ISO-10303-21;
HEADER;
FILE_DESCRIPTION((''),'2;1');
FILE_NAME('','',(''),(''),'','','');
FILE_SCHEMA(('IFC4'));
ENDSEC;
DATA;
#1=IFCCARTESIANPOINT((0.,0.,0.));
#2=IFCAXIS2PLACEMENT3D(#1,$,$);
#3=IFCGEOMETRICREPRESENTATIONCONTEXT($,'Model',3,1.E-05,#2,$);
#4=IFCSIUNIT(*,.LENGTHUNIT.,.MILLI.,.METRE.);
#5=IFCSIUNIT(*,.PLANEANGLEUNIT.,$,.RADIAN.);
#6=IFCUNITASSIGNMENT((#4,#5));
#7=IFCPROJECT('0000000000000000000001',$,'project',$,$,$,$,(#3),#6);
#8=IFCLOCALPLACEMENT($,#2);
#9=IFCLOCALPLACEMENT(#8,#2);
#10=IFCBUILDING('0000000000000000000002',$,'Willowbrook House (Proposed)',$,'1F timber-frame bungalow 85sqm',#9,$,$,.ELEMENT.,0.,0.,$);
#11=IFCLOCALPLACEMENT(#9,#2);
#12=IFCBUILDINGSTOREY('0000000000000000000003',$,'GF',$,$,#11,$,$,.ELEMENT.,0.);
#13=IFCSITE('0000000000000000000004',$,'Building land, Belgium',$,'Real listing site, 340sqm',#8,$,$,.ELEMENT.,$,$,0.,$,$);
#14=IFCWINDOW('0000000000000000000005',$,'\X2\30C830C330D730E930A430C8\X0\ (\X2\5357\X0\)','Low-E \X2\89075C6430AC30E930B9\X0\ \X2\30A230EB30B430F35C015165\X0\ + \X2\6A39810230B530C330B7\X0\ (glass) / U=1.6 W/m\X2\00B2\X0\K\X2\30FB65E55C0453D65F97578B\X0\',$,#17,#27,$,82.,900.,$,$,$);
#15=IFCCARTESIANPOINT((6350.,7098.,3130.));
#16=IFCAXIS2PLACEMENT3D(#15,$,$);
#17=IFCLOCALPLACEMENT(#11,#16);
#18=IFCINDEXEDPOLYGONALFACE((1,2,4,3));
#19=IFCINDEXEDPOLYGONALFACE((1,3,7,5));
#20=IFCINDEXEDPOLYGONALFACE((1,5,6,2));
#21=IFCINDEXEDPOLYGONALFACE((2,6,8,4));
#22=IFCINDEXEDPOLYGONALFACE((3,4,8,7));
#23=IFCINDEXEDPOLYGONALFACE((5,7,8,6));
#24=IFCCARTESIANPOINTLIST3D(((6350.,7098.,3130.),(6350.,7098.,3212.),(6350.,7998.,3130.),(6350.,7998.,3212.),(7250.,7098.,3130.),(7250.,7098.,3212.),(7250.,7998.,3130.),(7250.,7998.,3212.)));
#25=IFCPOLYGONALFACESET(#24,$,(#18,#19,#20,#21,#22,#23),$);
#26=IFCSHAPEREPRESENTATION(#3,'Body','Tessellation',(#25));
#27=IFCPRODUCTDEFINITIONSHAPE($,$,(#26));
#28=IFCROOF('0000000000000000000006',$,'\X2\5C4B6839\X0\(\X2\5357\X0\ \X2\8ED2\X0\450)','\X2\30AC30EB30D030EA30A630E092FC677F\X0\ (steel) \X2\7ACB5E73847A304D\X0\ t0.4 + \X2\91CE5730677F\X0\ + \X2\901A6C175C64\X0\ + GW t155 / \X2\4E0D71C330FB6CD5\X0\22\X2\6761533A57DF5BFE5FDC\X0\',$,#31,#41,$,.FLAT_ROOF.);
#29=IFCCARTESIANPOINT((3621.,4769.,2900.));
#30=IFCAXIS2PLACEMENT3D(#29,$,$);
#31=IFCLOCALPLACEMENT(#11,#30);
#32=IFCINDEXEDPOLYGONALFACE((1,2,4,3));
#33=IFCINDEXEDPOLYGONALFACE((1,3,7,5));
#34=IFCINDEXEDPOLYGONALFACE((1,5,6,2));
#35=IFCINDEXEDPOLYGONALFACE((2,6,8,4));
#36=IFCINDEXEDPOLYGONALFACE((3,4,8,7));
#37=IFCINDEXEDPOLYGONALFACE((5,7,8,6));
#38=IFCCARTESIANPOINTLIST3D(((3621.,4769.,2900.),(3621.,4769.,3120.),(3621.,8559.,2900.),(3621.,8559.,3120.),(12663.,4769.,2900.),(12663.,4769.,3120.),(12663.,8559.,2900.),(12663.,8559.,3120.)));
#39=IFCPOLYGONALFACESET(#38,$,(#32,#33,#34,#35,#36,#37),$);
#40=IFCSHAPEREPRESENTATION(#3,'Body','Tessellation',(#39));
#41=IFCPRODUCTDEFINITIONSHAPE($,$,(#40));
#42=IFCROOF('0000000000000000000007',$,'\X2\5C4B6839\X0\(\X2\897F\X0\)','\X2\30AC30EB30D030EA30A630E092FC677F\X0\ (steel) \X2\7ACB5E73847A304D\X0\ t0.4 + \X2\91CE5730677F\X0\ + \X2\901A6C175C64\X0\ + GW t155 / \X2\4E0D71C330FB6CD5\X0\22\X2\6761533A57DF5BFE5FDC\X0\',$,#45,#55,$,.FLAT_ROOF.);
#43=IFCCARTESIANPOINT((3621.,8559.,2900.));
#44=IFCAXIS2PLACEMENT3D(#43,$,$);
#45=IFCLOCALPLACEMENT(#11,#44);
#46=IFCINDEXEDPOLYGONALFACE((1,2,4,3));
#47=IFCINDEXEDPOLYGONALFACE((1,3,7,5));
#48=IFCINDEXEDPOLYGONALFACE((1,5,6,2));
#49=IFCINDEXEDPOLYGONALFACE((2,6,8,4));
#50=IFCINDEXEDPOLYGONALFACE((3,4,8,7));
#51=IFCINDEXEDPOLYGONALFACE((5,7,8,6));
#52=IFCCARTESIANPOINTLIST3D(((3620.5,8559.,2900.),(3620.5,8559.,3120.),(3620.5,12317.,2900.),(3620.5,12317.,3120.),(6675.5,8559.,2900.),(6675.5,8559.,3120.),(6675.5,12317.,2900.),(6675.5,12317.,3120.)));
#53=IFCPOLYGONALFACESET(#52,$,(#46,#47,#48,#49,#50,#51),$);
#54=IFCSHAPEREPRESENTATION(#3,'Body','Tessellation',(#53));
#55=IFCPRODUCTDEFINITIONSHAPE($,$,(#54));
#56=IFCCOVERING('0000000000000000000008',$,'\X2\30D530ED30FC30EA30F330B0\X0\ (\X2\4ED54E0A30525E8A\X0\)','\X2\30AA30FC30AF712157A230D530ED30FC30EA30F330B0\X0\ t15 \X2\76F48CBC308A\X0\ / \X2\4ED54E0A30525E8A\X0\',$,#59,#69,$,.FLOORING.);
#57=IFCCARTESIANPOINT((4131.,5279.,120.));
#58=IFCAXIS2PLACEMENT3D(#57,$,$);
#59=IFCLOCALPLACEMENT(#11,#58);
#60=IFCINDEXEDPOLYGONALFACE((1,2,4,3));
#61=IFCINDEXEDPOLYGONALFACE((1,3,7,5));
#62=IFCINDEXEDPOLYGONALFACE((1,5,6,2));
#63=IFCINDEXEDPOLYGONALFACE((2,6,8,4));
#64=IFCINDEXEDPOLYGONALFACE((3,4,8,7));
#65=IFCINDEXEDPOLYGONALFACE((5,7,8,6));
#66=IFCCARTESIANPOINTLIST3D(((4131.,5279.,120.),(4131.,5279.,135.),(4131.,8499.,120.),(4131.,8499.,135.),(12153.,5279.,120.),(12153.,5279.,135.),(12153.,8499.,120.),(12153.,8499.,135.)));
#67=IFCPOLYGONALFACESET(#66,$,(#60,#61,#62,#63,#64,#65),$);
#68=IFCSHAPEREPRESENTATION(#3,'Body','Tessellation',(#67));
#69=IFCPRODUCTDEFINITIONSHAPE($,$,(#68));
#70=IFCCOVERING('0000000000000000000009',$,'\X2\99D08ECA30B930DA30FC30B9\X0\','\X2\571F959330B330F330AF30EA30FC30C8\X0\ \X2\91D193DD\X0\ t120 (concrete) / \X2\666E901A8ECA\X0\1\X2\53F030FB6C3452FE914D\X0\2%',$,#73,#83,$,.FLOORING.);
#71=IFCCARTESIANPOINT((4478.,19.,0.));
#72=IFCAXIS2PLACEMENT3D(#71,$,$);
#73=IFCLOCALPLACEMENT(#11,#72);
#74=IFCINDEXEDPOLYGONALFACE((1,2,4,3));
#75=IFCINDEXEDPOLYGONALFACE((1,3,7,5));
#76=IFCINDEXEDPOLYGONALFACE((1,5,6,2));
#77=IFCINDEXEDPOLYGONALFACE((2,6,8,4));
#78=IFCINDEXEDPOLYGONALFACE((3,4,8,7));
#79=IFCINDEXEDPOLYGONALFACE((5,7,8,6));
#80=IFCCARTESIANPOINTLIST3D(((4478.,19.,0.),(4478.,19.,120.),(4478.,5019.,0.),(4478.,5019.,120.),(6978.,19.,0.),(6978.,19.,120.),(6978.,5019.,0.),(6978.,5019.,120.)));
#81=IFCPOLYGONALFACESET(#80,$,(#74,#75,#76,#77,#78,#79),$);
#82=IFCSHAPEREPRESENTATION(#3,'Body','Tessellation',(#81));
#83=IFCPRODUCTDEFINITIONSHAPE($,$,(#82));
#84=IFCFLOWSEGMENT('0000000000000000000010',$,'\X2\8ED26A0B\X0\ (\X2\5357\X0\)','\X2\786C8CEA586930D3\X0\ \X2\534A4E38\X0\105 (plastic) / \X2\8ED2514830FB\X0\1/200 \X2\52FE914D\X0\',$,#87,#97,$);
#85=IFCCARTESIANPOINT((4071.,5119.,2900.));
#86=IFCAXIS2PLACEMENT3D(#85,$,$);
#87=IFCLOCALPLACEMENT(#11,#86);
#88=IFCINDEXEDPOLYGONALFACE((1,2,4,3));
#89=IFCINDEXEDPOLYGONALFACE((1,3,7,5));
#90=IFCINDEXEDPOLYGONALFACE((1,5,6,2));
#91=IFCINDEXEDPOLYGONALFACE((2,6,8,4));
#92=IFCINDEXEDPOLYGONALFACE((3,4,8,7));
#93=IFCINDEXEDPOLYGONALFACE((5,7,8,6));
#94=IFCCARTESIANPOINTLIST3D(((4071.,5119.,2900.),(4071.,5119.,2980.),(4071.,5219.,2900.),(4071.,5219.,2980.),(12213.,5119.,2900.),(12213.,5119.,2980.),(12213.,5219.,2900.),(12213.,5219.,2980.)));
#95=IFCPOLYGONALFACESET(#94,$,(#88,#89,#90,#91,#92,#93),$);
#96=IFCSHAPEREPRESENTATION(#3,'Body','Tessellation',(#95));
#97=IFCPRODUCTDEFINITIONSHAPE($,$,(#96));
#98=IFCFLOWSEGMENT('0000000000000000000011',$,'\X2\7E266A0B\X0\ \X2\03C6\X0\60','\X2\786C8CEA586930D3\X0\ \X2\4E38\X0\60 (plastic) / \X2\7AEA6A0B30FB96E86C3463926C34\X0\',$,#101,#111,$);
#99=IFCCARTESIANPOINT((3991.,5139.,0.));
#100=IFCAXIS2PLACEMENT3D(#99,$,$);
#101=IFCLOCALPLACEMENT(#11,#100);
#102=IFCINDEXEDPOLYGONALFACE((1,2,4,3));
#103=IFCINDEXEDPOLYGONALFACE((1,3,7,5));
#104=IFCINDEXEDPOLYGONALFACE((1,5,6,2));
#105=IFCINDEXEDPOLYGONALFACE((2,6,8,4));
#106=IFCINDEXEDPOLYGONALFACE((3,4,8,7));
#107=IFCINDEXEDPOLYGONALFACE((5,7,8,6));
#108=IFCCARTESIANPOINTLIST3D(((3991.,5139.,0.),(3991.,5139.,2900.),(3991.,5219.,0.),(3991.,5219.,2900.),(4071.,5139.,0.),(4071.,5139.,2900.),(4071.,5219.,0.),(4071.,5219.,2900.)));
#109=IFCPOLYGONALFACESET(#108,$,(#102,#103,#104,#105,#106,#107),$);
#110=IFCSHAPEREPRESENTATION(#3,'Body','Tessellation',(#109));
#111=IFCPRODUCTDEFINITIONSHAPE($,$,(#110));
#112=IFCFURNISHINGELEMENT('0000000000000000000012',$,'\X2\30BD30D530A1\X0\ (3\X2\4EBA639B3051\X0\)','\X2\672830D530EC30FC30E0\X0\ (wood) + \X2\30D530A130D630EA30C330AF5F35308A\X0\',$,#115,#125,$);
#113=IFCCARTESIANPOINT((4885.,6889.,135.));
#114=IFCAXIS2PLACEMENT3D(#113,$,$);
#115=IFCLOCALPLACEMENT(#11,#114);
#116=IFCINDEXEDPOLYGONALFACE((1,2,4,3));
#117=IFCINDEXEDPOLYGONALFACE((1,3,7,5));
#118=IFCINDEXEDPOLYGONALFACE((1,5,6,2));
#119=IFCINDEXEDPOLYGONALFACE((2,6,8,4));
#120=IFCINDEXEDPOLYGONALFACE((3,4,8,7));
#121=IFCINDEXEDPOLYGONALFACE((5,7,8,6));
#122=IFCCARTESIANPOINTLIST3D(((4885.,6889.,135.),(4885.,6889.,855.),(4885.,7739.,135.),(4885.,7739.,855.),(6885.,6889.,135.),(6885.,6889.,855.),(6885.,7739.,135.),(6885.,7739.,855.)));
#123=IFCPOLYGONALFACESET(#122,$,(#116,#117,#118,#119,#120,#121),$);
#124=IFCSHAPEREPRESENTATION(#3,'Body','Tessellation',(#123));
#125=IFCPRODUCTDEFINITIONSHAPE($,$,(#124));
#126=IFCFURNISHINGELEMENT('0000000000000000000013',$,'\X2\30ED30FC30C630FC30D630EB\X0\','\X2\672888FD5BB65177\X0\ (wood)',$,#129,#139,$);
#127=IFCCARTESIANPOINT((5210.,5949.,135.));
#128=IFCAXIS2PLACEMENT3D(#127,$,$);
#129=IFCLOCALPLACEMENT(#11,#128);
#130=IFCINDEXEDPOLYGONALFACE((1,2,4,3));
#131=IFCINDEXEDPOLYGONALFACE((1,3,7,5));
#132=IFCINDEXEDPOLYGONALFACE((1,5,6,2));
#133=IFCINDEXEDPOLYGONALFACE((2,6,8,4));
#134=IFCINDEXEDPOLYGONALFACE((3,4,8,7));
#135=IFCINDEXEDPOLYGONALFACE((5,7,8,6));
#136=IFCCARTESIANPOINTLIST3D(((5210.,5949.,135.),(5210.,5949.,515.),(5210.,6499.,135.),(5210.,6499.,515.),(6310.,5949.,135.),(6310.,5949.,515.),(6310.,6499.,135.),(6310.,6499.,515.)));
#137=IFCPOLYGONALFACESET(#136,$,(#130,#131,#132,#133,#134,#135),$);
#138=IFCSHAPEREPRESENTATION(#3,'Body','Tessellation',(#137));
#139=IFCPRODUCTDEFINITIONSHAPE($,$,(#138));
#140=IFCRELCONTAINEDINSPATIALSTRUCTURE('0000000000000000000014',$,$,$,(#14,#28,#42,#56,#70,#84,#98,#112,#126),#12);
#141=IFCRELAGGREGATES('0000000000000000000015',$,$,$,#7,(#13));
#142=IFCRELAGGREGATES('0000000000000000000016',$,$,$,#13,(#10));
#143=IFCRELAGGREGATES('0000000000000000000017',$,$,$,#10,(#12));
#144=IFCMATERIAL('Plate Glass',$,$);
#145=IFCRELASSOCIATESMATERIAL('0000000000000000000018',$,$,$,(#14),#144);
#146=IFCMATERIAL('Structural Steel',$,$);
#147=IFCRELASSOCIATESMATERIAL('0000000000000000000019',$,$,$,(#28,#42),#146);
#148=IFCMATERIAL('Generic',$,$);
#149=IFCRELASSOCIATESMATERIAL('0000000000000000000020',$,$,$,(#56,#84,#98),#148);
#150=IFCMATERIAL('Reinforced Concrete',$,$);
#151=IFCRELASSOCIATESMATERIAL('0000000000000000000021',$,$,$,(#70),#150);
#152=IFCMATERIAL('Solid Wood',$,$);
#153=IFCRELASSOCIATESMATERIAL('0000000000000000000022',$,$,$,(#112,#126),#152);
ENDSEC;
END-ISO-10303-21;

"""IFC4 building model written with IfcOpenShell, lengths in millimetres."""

from ifc_helpers import new_model, si_unit, frame, frame_2d, origin, place, context, project, spatial, rectangle, extrude, material, element, save


model = new_model("IFC4")

# Units and contexts
model_context = context("Model", 3, precision=1e-05, world=origin())
ifc_project = project(units=[si_unit("LENGTHUNIT", "METRE", prefix="MILLI"), si_unit("PLANEANGLEUNIT", "RADIAN")], contexts=[model_context])

# Site, building, storey
site_placement = place(None, origin())
site = spatial("IfcSite", under=ifc_project, at=site_placement, Name="Building land, Belgium", ObjectType="Real listing site, 340sqm", CompositionType="ELEMENT", RefElevation=0.0)
building_placement = place(site_placement, origin())
building = spatial("IfcBuilding", under=site, at=building_placement, Name="Willowbrook House (Proposed)", ObjectType="1F timber-frame bungalow 85sqm", CompositionType="ELEMENT", ElevationOfRefHeight=0.0, ElevationOfTerrain=0.0)
storey_placement = place(building_placement, origin())
storey = spatial("IfcBuildingStorey", under=building, at=storey_placement, Name="GF", CompositionType="ELEMENT", Elevation=0.0)

# Shared definitions
ifc_material_1 = material(Name="Solid Wood")

# Shared definitions
ifc_material_2 = material(Name="Reinforced Concrete")

# Shared definitions
ifc_material_3 = material(Name="Plate Glass")

# Window
window_1_placement = place(storey_placement, frame((6350.0, 7098.0, 3130.0)))
element("IfcWindow", 1, at=window_1_placement, inside=storey, material=ifc_material_3, Name="トップライト (南)", Description="Low-E 複層ガラス アルゴン封入 + 樹脂サッシ (glass) / U=1.6 W/m²K・日射取得型", OverallHeight=82.0, OverallWidth=900.0, context=model_context, shape_type="SweptSolid", body=[
    extrude(rectangle(XDim=900.0, YDim=900.0, at=frame_2d((450.0, 450.0))), frame((6350.0, 7098.0, 3130.0)), (0.0, 0.0, 1.0), 82.0),
])

# Roofs
ifc_material_4 = material(Name="Structural Steel")
roof_1_placement = place(storey_placement, frame((3621.0, 4769.0, 2900.0)))
element("IfcRoof", 2, at=roof_1_placement, inside=storey, material=ifc_material_4, Name="屋根(南 軒450)", Description="ガルバリウム鋼板 (steel) 立平葺き t0.4 + 野地板 + 通気層 + GW t155 / 不燃・法22条区域対応", PredefinedType="FLAT_ROOF", context=model_context, shape_type="SweptSolid", body=[
    extrude(rectangle(XDim=9042.0, YDim=3790.0, at=frame_2d((4521.0, 1895.0))), frame((3621.0, 4769.0, 2900.0)), (0.0, 0.0, 1.0), 220.0),
])
roof_2_placement = place(storey_placement, frame((3621.0, 8559.0, 2900.0)))
element("IfcRoof", 3, at=roof_2_placement, inside=storey, material=ifc_material_4, Name="屋根(西)", Description="ガルバリウム鋼板 (steel) 立平葺き t0.4 + 野地板 + 通気層 + GW t155 / 不燃・法22条区域対応", PredefinedType="FLAT_ROOF", context=model_context, shape_type="SweptSolid", body=[
    extrude(rectangle(XDim=3055.0, YDim=3758.0, at=frame_2d((1527.0, 1879.0))), frame((3621.0, 8559.0, 2900.0)), (0.0, 0.0, 1.0), 220.0),
])

# Coverings
ifc_material_5 = material(Name="Generic")
covering_1_placement = place(storey_placement, frame((4131.0, 5279.0, 120.0)))
element("IfcCovering", 4, at=covering_1_placement, inside=storey, material=ifc_material_5, Name="フローリング (仕上げ床)", Description="オーク無垢フローリング t15 直貼り / 仕上げ床", PredefinedType="FLOORING", context=model_context, shape_type="SweptSolid", body=[
    extrude(rectangle(XDim=8022.0, YDim=3220.0, at=frame_2d((4011.0, 1610.0))), frame((4131.0, 5279.0, 120.0)), (0.0, 0.0, 1.0), 15.0),
])
covering_2_placement = place(storey_placement, frame((4478.0, 19.0, 0.0)))
element("IfcCovering", 5, at=covering_2_placement, inside=storey, material=ifc_material_2, Name="駐車スペース", Description="土間コンクリート 金鏝 t120 (concrete) / 普通車1台・水勾配2%", PredefinedType="FLOORING", context=model_context, shape_type="SweptSolid", body=[
    extrude(rectangle(XDim=2500.0, YDim=5000.0, at=frame_2d((1250.0, 2500.0))), frame((4478.0, 19.0, 0.0)), (0.0, 0.0, 1.0), 120.0),
])

# Flow segments
flow_segment_1_placement = place(storey_placement, frame((4071.0, 5119.0, 2900.0)))
element("IfcFlowSegment", 6, at=flow_segment_1_placement, inside=storey, material=ifc_material_5, Name="軒樋 (南)", Description="硬質塩ビ 半丸105 (plastic) / 軒先・1/200 勾配", context=model_context, shape_type="SweptSolid", body=[
    extrude(rectangle(XDim=8142.0, YDim=100.0, at=frame_2d((4071.0, 50.0))), frame((4071.0, 5119.0, 2900.0)), (0.0, 0.0, 1.0), 80.0),
])
flow_segment_2_placement = place(storey_placement, frame((3991.0, 5139.0, 0.0)))
element("IfcFlowSegment", 7, at=flow_segment_2_placement, inside=storey, material=ifc_material_5, Name="縦樋 φ60", Description="硬質塩ビ 丸60 (plastic) / 竪樋・雨水排水", context=model_context, shape_type="SweptSolid", body=[
    extrude(rectangle(XDim=80.0, YDim=80.0, at=frame_2d((40.0, 40.0))), frame((3991.0, 5139.0, 0.0)), (0.0, 0.0, 1.0), 2900.0),
])

# Furnishing elements
furnishing_1_placement = place(storey_placement, frame((4885.0, 6889.0, 135.0)))
element("IfcFurnishingElement", 8, at=furnishing_1_placement, inside=storey, material=ifc_material_1, Name="ソファ (3人掛け)", Description="木フレーム (wood) + ファブリック張り", context=model_context, shape_type="SweptSolid", body=[
    extrude(rectangle(XDim=2000.0, YDim=850.0, at=frame_2d((1000.0, 425.0))), frame((4885.0, 6889.0, 135.0)), (0.0, 0.0, 1.0), 720.0),
])
furnishing_2_placement = place(storey_placement, frame((5210.0, 5949.0, 135.0)))
element("IfcFurnishingElement", 9, at=furnishing_2_placement, inside=storey, material=ifc_material_1, Name="ローテーブル", Description="木製家具 (wood)", context=model_context, shape_type="SweptSolid", body=[
    extrude(rectangle(XDim=1100.0, YDim=550.0, at=frame_2d((550.0, 275.0))), frame((5210.0, 5949.0, 135.0)), (0.0, 0.0, 1.0), 380.0),
])

save(model, "model.ifc")
